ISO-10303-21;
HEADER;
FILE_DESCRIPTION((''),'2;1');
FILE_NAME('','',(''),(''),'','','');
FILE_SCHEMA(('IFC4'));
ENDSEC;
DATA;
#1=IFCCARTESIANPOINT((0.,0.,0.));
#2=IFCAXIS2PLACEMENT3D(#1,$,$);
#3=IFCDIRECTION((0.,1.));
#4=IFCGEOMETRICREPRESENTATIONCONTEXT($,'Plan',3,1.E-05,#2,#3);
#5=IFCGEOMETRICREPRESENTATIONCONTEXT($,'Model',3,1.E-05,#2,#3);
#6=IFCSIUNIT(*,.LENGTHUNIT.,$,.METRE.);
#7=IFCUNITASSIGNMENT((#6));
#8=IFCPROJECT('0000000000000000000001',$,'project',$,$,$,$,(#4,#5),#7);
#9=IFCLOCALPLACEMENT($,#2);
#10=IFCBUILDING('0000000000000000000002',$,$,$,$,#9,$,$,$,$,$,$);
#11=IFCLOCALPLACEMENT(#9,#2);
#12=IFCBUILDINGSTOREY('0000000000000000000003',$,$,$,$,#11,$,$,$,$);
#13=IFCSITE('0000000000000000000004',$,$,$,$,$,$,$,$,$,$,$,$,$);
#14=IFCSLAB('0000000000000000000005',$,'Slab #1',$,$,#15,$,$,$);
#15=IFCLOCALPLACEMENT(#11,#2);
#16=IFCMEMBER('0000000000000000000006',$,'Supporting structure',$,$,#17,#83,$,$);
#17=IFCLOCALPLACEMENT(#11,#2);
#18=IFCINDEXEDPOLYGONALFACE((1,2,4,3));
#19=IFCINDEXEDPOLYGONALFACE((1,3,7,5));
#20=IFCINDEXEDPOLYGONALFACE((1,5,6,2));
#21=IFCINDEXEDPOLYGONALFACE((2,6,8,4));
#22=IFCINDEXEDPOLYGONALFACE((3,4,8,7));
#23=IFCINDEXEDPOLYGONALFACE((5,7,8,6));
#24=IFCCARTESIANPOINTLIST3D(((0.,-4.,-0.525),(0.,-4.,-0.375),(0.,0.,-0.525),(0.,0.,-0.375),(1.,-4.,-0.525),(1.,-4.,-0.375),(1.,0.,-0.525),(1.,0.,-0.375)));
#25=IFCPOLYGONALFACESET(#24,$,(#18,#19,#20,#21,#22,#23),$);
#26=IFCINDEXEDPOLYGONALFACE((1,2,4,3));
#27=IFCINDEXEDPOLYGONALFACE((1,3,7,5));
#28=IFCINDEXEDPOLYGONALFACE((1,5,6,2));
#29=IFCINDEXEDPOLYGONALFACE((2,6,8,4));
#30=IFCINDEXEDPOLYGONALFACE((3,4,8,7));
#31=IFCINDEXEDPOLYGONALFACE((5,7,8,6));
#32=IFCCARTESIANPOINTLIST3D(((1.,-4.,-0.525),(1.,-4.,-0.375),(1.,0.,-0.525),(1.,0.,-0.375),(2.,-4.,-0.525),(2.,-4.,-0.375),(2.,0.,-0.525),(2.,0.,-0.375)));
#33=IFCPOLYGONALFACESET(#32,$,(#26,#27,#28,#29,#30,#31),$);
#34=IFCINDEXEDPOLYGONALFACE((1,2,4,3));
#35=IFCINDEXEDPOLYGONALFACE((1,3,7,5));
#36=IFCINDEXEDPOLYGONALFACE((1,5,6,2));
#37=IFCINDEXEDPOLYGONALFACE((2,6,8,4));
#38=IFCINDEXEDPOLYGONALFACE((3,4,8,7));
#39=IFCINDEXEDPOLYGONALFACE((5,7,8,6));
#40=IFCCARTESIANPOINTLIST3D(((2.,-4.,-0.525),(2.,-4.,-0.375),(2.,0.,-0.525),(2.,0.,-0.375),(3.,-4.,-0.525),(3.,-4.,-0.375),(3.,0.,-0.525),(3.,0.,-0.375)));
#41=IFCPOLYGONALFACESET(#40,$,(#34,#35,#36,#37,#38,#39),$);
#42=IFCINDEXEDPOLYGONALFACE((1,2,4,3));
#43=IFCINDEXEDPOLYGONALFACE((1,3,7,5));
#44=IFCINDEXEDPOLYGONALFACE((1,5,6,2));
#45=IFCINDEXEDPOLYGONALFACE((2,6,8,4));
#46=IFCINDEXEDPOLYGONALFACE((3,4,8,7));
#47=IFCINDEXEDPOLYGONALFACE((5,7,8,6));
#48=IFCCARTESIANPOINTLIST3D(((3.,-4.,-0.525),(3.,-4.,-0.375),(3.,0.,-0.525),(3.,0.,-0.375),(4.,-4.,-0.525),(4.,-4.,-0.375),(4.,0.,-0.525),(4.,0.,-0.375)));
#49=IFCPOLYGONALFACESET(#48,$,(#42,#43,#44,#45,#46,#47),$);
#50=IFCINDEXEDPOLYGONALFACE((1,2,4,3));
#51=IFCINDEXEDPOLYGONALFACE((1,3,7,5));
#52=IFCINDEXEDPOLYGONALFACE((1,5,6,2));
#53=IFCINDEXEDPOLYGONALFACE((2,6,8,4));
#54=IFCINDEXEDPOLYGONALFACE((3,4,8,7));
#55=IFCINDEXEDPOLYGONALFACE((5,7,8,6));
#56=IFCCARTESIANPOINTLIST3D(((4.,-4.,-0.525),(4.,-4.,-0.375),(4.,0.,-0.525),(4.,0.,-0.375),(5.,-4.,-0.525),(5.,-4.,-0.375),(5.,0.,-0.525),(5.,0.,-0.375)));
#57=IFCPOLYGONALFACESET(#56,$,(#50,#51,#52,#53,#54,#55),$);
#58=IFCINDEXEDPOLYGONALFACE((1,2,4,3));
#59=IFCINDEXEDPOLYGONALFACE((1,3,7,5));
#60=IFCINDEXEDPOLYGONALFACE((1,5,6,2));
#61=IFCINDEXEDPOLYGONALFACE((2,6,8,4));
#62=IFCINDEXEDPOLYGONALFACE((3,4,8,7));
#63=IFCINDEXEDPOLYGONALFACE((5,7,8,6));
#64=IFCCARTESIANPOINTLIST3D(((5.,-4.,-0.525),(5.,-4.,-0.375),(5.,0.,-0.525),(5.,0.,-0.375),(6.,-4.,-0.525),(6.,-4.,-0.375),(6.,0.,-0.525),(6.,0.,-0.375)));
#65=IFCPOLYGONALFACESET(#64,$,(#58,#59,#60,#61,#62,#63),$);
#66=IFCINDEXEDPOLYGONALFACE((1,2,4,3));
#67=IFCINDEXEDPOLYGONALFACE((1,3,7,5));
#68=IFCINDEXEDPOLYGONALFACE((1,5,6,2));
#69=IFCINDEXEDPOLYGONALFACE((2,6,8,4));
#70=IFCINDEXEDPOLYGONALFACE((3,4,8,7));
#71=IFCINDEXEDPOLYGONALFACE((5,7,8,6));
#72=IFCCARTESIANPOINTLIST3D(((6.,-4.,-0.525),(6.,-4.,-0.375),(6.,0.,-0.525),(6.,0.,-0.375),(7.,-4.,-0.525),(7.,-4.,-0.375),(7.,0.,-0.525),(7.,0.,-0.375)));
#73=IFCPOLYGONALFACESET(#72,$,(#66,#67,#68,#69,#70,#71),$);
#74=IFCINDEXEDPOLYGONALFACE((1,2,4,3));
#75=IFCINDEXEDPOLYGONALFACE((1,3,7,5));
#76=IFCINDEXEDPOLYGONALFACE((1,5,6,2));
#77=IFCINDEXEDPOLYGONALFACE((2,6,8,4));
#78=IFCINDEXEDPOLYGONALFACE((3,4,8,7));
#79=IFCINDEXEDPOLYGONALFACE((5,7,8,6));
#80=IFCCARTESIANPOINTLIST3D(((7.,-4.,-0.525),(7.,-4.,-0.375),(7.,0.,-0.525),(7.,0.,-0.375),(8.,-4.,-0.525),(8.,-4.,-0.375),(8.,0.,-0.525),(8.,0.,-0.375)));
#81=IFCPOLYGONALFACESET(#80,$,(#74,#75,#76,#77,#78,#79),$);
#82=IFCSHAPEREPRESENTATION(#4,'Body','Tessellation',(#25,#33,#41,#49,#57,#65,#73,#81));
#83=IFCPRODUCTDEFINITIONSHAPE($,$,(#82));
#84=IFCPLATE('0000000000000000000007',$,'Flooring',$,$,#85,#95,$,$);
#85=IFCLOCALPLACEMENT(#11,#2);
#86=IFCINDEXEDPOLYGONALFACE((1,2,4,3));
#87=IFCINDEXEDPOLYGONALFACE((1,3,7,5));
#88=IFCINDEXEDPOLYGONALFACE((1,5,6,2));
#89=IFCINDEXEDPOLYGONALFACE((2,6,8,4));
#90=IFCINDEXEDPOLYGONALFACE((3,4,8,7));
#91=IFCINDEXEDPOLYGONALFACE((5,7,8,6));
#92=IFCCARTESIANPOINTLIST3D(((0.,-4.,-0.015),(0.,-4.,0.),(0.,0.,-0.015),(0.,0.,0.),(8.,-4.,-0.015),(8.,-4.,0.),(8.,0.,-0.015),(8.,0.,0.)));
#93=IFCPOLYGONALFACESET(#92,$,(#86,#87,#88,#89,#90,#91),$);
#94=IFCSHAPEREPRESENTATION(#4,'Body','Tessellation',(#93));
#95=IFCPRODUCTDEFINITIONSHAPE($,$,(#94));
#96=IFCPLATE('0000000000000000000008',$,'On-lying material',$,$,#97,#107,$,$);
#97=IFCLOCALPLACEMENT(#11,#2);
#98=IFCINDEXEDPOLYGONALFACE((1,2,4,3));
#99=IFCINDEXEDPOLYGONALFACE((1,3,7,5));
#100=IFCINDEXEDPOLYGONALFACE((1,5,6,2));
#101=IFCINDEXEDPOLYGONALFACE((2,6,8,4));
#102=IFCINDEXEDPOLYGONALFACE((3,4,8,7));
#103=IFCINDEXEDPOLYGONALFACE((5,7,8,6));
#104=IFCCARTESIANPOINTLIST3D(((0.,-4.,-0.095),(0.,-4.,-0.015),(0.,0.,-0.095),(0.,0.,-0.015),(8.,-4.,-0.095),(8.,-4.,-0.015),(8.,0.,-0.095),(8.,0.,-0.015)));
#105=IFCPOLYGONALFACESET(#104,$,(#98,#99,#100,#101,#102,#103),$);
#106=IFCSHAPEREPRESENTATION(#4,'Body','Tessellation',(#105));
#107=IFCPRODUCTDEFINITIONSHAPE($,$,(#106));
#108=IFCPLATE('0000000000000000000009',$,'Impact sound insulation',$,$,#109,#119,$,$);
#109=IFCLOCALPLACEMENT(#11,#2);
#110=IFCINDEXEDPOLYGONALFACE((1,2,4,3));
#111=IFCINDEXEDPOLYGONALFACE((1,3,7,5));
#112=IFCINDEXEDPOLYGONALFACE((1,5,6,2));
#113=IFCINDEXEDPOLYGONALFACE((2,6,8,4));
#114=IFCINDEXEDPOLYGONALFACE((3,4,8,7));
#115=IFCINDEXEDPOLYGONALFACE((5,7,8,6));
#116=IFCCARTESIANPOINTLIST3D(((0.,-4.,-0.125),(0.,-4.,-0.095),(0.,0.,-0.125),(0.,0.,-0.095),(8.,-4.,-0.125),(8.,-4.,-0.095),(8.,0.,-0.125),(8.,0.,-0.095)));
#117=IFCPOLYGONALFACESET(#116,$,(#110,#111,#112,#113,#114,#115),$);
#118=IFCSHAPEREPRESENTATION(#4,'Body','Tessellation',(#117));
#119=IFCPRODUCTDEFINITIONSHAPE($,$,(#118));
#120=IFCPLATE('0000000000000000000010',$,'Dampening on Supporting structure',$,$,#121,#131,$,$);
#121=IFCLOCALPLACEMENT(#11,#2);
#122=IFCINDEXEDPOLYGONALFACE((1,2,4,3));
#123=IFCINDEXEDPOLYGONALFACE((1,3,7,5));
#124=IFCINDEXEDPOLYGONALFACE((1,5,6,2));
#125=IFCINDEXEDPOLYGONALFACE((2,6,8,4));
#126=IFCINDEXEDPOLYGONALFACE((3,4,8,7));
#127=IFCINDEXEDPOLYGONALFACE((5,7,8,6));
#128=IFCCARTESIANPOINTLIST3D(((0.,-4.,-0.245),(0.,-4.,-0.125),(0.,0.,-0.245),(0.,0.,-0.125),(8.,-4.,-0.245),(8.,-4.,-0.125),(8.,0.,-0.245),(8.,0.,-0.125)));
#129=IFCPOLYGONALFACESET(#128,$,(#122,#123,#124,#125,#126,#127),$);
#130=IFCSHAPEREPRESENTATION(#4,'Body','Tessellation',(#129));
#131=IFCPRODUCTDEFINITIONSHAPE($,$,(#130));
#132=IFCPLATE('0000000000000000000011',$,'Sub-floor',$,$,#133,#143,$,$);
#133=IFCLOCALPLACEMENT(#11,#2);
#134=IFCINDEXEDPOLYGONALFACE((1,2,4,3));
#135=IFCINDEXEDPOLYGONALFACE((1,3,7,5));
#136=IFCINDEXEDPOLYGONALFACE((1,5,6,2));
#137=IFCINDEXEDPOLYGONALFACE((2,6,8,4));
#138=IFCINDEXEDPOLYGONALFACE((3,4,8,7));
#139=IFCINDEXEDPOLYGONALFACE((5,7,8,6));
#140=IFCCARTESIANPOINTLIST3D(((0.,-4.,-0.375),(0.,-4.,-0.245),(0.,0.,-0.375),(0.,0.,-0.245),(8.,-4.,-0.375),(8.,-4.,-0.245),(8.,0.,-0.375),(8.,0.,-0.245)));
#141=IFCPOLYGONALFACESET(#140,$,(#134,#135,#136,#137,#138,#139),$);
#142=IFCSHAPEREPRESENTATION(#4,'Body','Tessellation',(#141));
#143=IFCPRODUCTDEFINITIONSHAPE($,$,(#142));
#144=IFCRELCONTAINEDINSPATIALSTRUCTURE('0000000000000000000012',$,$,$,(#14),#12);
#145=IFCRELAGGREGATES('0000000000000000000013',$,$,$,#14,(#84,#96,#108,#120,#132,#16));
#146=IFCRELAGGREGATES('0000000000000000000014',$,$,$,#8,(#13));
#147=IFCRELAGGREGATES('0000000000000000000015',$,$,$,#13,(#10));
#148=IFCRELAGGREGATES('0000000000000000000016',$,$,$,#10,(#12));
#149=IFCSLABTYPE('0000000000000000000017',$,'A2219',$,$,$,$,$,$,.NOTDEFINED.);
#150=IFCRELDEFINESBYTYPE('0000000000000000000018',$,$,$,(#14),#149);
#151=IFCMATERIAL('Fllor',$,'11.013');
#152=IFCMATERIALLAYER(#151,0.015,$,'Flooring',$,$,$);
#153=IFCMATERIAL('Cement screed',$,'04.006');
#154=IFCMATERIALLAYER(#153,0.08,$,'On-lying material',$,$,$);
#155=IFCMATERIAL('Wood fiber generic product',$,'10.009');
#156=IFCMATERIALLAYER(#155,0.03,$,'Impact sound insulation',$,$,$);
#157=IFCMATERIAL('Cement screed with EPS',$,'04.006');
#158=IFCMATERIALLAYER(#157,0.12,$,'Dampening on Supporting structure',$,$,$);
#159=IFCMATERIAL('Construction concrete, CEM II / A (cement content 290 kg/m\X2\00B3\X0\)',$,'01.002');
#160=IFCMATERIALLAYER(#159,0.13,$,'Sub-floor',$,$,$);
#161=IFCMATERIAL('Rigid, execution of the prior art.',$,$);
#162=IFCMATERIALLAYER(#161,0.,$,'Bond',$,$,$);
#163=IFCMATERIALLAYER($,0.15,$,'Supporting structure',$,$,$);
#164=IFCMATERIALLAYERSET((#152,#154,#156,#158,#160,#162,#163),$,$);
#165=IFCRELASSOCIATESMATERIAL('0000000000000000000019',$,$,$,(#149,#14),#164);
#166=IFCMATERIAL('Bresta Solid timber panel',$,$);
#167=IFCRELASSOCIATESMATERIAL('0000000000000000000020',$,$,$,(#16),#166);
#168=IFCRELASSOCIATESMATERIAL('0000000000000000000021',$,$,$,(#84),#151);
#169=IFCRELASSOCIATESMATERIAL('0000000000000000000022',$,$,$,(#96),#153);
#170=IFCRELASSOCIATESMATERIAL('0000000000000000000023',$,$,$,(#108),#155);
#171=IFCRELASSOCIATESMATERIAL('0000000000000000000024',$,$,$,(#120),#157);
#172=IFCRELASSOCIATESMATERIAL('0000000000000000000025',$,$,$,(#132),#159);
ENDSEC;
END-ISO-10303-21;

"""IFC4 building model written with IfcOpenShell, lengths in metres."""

from ifc_helpers import new_model, si_unit, direction, frame, frame_2d, origin, origin_with_axes, place, context, project, spatial, rectangle, extrude, material, layer, layer_set, type_object, element, aggregate, save


model = new_model("IFC4")

# Units and contexts
plan_context = context("Plan", 3, precision=1e-05, world=origin(), true_north=direction((0.0, 1.0)))
model_context = context("Model", 3, precision=1e-05, world=origin(), true_north=direction((0.0, 1.0)))
ifc_project = project(units=[si_unit("LENGTHUNIT", "METRE")], contexts=[plan_context, model_context])

# Site, building, storey
site = spatial("IfcSite", under=ifc_project)
building_placement = place(None, origin())
building = spatial("IfcBuilding", under=site, at=building_placement)
storey_placement = place(building_placement, origin())
storey = spatial("IfcBuildingStorey", under=building, at=storey_placement)

# Slab, member, plates
ifc_material_1 = material(Name="Fllor", Category="11.013")
ifc_layer_1 = layer(ifc_material_1, 0.015, Name="Flooring")
ifc_material_2 = material(Name="Cement screed", Category="04.006")
ifc_layer_2 = layer(ifc_material_2, 0.08, Name="On-lying material")
ifc_material_3 = material(Name="Wood fiber generic product", Category="10.009")
ifc_layer_3 = layer(ifc_material_3, 0.03, Name="Impact sound insulation")
ifc_material_4 = material(Name="Cement screed with EPS", Category="04.006")
ifc_layer_4 = layer(ifc_material_4, 0.12, Name="Dampening on Supporting structure")
ifc_material_5 = material(Name="Construction concrete, CEM II / A (cement content 290 kg/m³)", Category="01.002")
ifc_layer_5 = layer(ifc_material_5, 0.13, Name="Sub-floor")
ifc_material_6 = material(Name="Rigid, execution of the prior art.")
ifc_layer_6 = layer(ifc_material_6, 0.0, Name="Bond")
ifc_layer_7 = layer(None, 0.15, Name="Supporting structure")
ifc_layer_set = layer_set([ifc_layer_1, ifc_layer_2, ifc_layer_3, ifc_layer_4, ifc_layer_5, ifc_layer_6, ifc_layer_7])
slab_type = type_object("IfcSlabType", Name="A2219", PredefinedType="NOTDEFINED", material=ifc_layer_set)
slab_placement = place(None, frame((0.0, 0.0, 0.0), z_axis=(0.0, 0.0, -1.0), x_axis=(1.0, 0.0, 0.0)))
slab = element("IfcSlab", 1, at=slab_placement, inside=storey, type_object=slab_type, material=ifc_layer_set, Name="Slab #1")
ifc_material_7 = material(Name="Bresta Solid timber panel")
member_placement = place(slab_placement, origin())
member = element("IfcMember", 2, at=member_placement, material=ifc_material_7, Name="Supporting structure", context=plan_context, shape_type="SweptSolid", body=[
    extrude(rectangle(XDim=1.0, YDim=0.15, at=frame_2d((0.5, 0.075), x_axis=(1.0, 0.0))), frame((0.0, 4.0, 0.375), z_axis=(0.0, -1.0, 0.0), x_axis=(1.0, 0.0, 0.0)), (0.0, 0.0, 1.0), 4.0),
    extrude(rectangle(XDim=1.0, YDim=0.15, at=frame_2d((0.5, 0.075), x_axis=(1.0, 0.0))), frame((1.0, 4.0, 0.375), z_axis=(0.0, -1.0, 0.0), x_axis=(1.0, 0.0, 0.0)), (0.0, 0.0, 1.0), 4.0),
    extrude(rectangle(XDim=1.0, YDim=0.15, at=frame_2d((0.5, 0.075), x_axis=(1.0, 0.0))), frame((2.0, 4.0, 0.375), z_axis=(0.0, -1.0, 0.0), x_axis=(1.0, 0.0, 0.0)), (0.0, 0.0, 1.0), 4.0),
    extrude(rectangle(XDim=1.0, YDim=0.15, at=frame_2d((0.5, 0.075), x_axis=(1.0, 0.0))), frame((3.0, 4.0, 0.375), z_axis=(0.0, -1.0, 0.0), x_axis=(1.0, 0.0, 0.0)), (0.0, 0.0, 1.0), 4.0),
    extrude(rectangle(XDim=1.0, YDim=0.15, at=frame_2d((0.5, 0.075), x_axis=(1.0, 0.0))), frame((4.0, 4.0, 0.375), z_axis=(0.0, -1.0, 0.0), x_axis=(1.0, 0.0, 0.0)), (0.0, 0.0, 1.0), 4.0),
    extrude(rectangle(XDim=1.0, YDim=0.15, at=frame_2d((0.5, 0.075), x_axis=(1.0, 0.0))), frame((5.0, 4.0, 0.375), z_axis=(0.0, -1.0, 0.0), x_axis=(1.0, 0.0, 0.0)), (0.0, 0.0, 1.0), 4.0),
    extrude(rectangle(XDim=1.0, YDim=0.15, at=frame_2d((0.5, 0.075), x_axis=(1.0, 0.0))), frame((6.0, 4.0, 0.375), z_axis=(0.0, -1.0, 0.0), x_axis=(1.0, 0.0, 0.0)), (0.0, 0.0, 1.0), 4.0),
    extrude(rectangle(XDim=1.0, YDim=0.15, at=frame_2d((0.5, 0.075), x_axis=(1.0, 0.0))), frame((7.0, 4.0, 0.375), z_axis=(0.0, -1.0, 0.0), x_axis=(1.0, 0.0, 0.0)), (0.0, 0.0, 1.0), 4.0),
])
plate_1_placement = place(slab_placement, origin())
plate_1 = element("IfcPlate", 3, at=plate_1_placement, material=ifc_material_1, Name="Flooring", context=plan_context, shape_type="SweptSolid", body=[
    extrude(rectangle(XDim=8.0, YDim=4.0, at=frame_2d((4.0, 2.0), x_axis=(1.0, 0.0))), origin_with_axes(), (0.0, 0.0, 1.0), 0.015),
])
plate_2_placement = place(slab_placement, origin())
plate_2 = element("IfcPlate", 4, at=plate_2_placement, material=ifc_material_2, Name="On-lying material", context=plan_context, shape_type="SweptSolid", body=[
    extrude(rectangle(XDim=8.0, YDim=4.0, at=frame_2d((4.0, 2.0), x_axis=(1.0, 0.0))), frame((0.0, 0.0, 0.015), z_axis=(0.0, 0.0, 1.0), x_axis=(1.0, 0.0, 0.0)), (0.0, 0.0, 1.0), 0.08),
])
plate_3_placement = place(slab_placement, origin())
plate_3 = element("IfcPlate", 5, at=plate_3_placement, material=ifc_material_3, Name="Impact sound insulation", context=plan_context, shape_type="SweptSolid", body=[
    extrude(rectangle(XDim=8.0, YDim=4.0, at=frame_2d((4.0, 2.0), x_axis=(1.0, 0.0))), frame((0.0, 0.0, 0.095), z_axis=(0.0, 0.0, 1.0), x_axis=(1.0, 0.0, 0.0)), (0.0, 0.0, 1.0), 0.03),
])
plate_4_placement = place(slab_placement, origin())
plate_4 = element("IfcPlate", 6, at=plate_4_placement, material=ifc_material_4, Name="Dampening on Supporting structure", context=plan_context, shape_type="SweptSolid", body=[
    extrude(rectangle(XDim=8.0, YDim=4.0, at=frame_2d((4.0, 2.0), x_axis=(1.0, 0.0))), frame((0.0, 0.0, 0.125), z_axis=(0.0, 0.0, 1.0), x_axis=(1.0, 0.0, 0.0)), (0.0, 0.0, 1.0), 0.12),
])
plate_5_placement = place(slab_placement, origin())
plate_5 = element("IfcPlate", 7, at=plate_5_placement, material=ifc_material_5, Name="Sub-floor", context=plan_context, shape_type="SweptSolid", body=[
    extrude(rectangle(XDim=8.0, YDim=4.0, at=frame_2d((4.0, 2.0), x_axis=(1.0, 0.0))), frame((0.0, 0.0, 0.245), z_axis=(0.0, 0.0, 1.0), x_axis=(1.0, 0.0, 0.0)), (0.0, 0.0, 1.0), 0.13),
])
aggregate(slab, [plate_1, plate_2, plate_3, plate_4, plate_5, member])

save(model, "model.ifc")
